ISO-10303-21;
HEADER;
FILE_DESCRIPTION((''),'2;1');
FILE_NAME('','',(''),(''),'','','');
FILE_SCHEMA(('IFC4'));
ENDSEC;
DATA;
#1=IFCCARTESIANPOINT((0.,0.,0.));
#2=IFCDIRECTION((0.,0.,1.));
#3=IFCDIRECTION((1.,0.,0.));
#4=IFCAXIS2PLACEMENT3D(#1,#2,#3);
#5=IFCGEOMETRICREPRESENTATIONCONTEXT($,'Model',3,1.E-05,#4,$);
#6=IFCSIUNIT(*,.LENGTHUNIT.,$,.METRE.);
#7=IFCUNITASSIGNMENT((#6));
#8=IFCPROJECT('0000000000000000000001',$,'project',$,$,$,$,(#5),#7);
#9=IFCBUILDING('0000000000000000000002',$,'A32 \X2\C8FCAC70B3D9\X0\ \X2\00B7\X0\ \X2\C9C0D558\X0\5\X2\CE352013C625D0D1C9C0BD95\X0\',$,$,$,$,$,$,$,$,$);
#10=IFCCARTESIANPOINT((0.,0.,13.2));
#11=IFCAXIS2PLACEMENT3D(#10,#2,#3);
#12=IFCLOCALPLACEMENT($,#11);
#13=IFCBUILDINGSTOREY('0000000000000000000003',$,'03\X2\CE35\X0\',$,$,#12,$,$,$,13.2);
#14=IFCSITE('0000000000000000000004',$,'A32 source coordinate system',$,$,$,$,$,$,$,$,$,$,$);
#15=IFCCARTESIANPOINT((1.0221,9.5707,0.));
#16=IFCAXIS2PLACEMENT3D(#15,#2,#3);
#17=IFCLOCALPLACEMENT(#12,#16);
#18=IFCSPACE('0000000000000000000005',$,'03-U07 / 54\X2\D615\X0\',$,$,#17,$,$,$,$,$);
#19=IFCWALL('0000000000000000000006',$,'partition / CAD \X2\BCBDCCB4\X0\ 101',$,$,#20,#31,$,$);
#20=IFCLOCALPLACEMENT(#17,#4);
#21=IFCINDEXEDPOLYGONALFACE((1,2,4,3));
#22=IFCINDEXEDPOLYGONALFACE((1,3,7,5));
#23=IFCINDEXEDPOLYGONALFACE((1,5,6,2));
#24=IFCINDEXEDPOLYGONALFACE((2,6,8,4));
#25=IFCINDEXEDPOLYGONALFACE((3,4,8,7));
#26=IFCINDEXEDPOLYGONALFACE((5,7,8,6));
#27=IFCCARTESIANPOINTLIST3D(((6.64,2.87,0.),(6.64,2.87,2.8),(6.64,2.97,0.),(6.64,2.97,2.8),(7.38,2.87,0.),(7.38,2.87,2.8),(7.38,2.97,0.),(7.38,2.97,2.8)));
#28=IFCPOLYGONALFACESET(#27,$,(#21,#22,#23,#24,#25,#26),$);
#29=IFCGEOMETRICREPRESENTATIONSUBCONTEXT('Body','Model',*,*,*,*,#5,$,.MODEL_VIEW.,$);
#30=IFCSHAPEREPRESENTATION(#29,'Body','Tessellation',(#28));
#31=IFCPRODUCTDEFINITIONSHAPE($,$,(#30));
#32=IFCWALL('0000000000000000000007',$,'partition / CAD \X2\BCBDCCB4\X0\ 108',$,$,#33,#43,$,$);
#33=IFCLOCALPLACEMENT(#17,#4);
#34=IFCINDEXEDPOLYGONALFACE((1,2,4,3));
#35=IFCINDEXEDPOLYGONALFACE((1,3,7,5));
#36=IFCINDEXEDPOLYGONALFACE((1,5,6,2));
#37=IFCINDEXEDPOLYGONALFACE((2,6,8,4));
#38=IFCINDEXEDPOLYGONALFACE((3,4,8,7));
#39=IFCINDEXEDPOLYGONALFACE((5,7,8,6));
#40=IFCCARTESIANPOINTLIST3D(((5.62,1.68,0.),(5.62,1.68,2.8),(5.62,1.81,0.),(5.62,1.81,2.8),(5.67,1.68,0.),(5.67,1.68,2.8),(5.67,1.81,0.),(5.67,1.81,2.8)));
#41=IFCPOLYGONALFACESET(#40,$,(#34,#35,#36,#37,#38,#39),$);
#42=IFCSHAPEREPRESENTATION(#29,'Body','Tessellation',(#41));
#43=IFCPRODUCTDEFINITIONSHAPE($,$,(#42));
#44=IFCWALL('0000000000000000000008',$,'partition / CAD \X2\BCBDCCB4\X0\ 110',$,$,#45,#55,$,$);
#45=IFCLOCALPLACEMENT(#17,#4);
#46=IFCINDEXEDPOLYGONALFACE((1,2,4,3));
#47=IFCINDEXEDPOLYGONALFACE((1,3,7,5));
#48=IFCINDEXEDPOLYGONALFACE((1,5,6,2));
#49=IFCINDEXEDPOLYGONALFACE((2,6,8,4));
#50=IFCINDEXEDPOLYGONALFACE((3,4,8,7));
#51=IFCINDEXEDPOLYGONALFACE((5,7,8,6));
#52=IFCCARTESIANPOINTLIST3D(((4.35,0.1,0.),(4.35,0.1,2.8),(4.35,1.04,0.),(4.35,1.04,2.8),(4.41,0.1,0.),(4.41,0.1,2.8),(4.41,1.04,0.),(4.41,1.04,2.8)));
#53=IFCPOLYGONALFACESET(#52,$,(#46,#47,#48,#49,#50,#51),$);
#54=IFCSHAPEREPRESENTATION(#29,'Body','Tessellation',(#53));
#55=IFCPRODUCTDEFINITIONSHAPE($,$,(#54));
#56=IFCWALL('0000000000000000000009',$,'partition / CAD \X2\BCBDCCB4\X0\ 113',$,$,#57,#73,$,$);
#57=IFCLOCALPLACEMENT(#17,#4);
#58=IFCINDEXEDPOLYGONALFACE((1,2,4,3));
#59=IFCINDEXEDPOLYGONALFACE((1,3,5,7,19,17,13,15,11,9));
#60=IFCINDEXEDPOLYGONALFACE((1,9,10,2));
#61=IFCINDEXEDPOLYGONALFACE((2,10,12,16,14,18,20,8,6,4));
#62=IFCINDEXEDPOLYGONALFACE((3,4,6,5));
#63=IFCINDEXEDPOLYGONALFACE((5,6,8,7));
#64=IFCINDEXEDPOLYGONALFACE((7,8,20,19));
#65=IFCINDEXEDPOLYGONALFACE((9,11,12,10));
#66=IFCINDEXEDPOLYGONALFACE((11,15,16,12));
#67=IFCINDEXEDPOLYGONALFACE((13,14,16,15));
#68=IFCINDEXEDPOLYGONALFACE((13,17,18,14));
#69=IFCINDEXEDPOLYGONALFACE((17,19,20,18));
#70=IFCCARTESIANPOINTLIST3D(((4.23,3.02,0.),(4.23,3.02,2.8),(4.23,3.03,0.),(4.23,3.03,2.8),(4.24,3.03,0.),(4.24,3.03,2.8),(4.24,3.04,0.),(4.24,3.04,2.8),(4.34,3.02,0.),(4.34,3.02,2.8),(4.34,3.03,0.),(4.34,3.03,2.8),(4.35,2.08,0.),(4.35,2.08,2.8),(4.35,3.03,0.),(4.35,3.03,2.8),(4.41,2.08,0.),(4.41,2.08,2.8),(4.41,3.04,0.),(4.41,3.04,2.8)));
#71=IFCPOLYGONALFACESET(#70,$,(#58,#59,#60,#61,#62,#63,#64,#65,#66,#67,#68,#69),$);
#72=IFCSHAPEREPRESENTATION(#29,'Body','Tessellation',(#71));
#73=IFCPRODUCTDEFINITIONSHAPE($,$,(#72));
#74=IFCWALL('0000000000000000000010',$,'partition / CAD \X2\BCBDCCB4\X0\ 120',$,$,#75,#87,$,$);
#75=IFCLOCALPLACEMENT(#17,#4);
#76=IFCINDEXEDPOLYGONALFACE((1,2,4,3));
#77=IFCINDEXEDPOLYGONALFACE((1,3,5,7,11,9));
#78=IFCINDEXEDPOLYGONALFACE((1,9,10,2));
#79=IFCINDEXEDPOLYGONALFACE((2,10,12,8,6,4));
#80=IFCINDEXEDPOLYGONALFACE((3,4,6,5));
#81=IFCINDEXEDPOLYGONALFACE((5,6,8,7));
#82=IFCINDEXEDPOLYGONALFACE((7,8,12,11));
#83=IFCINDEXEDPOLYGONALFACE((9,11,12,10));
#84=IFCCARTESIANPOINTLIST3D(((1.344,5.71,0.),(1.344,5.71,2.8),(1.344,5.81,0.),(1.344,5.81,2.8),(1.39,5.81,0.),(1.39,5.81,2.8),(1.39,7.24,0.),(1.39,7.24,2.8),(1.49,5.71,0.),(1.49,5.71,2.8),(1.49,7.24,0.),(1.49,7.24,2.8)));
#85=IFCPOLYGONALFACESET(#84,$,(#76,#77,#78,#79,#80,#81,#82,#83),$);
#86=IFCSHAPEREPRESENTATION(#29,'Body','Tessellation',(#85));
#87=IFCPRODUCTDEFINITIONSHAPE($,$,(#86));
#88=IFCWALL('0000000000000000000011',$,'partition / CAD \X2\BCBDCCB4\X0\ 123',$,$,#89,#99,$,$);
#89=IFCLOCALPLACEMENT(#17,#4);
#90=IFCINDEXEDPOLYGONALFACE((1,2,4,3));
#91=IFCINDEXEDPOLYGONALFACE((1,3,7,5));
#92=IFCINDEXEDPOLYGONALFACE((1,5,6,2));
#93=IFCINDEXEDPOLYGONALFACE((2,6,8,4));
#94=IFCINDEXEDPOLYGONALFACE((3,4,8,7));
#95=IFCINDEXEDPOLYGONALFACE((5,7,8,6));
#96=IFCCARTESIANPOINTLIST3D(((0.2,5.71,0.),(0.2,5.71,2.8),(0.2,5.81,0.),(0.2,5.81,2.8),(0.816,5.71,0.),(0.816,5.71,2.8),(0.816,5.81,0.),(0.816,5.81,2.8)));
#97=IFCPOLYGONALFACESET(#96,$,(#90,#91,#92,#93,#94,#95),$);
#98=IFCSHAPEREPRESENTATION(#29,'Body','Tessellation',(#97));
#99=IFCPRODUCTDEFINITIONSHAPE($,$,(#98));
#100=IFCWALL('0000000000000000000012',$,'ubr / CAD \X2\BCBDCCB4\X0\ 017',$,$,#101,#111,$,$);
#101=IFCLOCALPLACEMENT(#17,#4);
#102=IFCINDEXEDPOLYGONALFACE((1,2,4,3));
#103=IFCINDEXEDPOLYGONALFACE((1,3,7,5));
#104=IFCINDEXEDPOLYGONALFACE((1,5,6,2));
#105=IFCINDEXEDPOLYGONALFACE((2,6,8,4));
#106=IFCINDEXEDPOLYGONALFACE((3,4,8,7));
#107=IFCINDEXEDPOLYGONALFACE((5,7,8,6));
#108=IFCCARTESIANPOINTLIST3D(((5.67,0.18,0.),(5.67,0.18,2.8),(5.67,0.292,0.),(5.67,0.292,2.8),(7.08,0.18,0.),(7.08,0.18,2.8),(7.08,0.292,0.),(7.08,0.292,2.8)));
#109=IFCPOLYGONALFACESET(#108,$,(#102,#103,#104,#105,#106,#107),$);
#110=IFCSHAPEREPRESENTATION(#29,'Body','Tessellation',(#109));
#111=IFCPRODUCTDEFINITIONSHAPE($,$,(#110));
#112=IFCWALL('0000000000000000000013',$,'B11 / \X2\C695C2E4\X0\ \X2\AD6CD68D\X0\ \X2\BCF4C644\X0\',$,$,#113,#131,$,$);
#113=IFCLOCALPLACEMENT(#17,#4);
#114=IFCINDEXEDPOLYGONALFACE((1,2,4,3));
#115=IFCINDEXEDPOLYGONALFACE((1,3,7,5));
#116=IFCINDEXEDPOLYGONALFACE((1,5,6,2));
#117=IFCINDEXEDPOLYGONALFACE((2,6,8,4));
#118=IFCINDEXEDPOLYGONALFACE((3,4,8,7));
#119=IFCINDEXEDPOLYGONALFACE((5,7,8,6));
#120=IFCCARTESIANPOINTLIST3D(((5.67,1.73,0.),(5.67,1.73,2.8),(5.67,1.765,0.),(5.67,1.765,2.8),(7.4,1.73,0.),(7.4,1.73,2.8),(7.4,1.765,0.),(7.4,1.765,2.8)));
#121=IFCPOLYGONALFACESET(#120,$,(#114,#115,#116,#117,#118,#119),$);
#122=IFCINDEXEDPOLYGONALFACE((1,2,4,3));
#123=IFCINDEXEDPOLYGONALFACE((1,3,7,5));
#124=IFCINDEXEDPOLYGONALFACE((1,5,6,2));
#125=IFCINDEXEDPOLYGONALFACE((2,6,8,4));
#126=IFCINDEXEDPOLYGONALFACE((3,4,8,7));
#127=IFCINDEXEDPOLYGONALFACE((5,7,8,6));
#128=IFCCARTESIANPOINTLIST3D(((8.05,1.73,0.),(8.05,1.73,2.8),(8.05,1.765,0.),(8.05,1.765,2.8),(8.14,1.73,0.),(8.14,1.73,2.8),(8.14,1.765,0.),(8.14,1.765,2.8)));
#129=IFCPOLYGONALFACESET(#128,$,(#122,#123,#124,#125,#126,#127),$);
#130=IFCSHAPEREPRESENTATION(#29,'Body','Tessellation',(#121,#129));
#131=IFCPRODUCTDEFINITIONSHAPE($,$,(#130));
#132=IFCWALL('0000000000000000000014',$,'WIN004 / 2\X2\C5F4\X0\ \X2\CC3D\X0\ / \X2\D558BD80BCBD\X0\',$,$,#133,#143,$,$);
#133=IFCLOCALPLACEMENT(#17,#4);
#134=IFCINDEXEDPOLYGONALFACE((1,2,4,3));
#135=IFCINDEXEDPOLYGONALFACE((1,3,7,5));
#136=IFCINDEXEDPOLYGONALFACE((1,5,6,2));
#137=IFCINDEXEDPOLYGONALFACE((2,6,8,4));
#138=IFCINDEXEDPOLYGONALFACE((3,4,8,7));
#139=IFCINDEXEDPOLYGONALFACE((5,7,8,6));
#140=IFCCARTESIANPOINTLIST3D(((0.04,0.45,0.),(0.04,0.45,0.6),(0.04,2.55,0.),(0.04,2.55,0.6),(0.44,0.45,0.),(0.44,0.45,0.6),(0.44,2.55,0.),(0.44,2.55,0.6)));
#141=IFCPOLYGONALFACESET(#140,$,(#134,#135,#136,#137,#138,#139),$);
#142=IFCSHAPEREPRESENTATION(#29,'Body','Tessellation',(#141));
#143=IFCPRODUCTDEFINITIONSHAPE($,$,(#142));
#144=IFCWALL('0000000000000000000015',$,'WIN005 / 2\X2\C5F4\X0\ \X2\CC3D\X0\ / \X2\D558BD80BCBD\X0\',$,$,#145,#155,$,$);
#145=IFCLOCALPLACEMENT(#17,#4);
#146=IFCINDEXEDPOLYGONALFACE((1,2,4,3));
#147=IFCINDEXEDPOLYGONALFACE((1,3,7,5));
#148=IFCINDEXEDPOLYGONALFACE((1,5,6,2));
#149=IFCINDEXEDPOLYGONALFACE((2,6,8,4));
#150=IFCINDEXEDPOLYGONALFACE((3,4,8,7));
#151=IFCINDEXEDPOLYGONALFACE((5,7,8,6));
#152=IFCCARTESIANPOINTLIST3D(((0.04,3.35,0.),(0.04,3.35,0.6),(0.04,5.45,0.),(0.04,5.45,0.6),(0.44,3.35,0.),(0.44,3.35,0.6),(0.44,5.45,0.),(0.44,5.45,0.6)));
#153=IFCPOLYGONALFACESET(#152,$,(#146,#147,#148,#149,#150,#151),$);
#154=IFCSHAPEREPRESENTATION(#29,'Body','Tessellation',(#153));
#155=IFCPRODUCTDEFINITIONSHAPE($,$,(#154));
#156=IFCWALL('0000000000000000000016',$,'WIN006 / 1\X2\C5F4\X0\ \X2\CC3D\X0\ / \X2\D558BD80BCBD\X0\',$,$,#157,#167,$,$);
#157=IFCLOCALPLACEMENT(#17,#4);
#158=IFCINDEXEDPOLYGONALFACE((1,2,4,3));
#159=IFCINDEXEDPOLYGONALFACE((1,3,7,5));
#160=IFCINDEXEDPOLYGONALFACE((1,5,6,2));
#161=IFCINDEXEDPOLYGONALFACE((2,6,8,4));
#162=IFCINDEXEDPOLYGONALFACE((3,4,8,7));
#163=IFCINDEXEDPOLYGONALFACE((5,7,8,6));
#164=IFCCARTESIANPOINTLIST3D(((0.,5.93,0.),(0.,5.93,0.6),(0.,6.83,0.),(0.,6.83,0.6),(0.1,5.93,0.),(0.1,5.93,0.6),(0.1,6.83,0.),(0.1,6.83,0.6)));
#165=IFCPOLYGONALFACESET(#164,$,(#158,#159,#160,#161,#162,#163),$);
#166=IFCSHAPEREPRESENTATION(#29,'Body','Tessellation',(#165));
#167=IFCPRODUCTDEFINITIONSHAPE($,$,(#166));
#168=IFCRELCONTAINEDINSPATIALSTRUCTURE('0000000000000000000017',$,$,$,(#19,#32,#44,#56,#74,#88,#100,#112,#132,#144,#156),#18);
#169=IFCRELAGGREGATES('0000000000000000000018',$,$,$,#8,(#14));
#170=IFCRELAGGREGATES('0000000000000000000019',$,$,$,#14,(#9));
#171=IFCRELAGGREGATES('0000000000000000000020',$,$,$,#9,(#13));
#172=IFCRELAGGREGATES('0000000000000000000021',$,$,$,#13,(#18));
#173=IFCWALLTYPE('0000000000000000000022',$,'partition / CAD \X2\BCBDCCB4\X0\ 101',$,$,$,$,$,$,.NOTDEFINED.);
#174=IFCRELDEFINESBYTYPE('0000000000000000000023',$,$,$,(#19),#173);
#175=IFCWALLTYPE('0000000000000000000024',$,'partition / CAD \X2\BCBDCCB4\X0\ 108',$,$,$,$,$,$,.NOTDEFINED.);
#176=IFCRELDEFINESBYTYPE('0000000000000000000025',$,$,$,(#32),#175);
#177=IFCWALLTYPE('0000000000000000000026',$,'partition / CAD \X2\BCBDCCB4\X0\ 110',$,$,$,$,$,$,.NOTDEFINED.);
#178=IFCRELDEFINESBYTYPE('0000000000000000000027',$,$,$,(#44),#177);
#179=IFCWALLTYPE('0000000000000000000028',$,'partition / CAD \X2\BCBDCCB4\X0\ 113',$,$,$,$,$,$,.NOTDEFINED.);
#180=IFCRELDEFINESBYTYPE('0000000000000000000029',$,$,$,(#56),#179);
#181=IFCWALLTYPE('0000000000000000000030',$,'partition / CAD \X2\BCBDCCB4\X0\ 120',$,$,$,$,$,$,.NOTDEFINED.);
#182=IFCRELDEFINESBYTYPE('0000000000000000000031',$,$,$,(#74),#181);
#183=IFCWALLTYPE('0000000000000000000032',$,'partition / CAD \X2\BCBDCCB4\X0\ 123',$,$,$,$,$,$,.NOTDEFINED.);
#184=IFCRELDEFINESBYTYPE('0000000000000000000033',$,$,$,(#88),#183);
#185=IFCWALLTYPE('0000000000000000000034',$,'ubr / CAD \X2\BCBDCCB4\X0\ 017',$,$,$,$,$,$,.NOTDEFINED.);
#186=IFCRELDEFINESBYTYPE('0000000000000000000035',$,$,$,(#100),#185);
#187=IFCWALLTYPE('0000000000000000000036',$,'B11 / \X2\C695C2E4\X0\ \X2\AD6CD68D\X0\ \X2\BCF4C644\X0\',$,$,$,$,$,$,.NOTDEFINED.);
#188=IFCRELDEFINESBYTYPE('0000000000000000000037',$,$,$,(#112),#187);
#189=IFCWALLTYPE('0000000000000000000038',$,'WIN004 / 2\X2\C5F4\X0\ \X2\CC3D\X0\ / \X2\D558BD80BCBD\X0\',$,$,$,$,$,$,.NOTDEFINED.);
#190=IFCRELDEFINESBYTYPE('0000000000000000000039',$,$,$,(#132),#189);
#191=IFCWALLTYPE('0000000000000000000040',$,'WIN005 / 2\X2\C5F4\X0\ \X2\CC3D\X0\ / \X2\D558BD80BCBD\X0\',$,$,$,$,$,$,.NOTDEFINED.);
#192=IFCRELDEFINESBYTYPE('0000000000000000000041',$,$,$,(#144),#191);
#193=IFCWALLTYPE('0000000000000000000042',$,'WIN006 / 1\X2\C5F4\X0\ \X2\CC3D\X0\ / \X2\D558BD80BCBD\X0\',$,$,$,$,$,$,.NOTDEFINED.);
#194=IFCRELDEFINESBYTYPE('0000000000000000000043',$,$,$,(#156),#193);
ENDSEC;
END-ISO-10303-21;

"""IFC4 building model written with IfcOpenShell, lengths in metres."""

from ifc_helpers import new_model, si_unit, frame, origin, origin_with_axes, place, context, subcontext, project, spatial, polyline, outline, extrude, source, transform, mapped, type_object, type_shapes, element, save


model = new_model("IFC4")

# Units and contexts
model_context = context("Model", 3, precision=1e-05, world=origin_with_axes())
body_context = subcontext(model_context, "Body", "Model", "MODEL_VIEW")
ifc_project = project(units=[si_unit("LENGTHUNIT", "METRE")], contexts=[model_context])

# Site, building, storey
storey_placement = place(None, frame((0.0, 0.0, 13.2), z_axis=(0.0, 0.0, 1.0), x_axis=(1.0, 0.0, 0.0)))
site = spatial("IfcSite", under=ifc_project, Name="A32 source coordinate system")
building = spatial("IfcBuilding", under=site, Name="A32 주거동 · 지하5층–옥탑지붕")
storey = spatial("IfcBuildingStorey", under=building, at=storey_placement, Name="03층", Elevation=13.2)

# Shared definitions
space_1_placement = place(storey_placement, frame((1.0221, 9.5707, 0.0), z_axis=(0.0, 0.0, 1.0), x_axis=(1.0, 0.0, 0.0)))
space_1 = spatial("IfcSpace", under=storey, at=space_1_placement, Name="03-U07 / 54형")

# Walls
wall_type_1 = type_object("IfcWallType", Name="partition / CAD 벽체 101", PredefinedType="NOTDEFINED")
shared_shape_1 = source(origin(), body_context, "Body", "SweptSolid", [
    extrude(outline(polyline([(7.38, 2.97), (7.38, 2.87), (6.64, 2.87), (6.64, 2.97), (7.38, 2.97)])), origin(), (0.0, 0.0, 1.0), 2.8),
])
type_shapes(wall_type_1, [shared_shape_1])
wall_1_placement = place(space_1_placement, origin_with_axes())
element("IfcWall", 1, at=wall_1_placement, inside=space_1, type_object=wall_type_1, Name="partition / CAD 벽체 101", context=body_context, shape_type="MappedRepresentation", body=[
    mapped(shared_shape_1, transform((0.0, 0.0, 0.0), scale=1.0)),
])
wall_type_2 = type_object("IfcWallType", Name="partition / CAD 벽체 108", PredefinedType="NOTDEFINED")
shared_shape_2 = source(origin(), body_context, "Body", "SweptSolid", [
    extrude(outline(polyline([(5.67, 1.68), (5.62, 1.68), (5.62, 1.81), (5.67, 1.81), (5.67, 1.68)])), origin(), (0.0, 0.0, 1.0), 2.8),
])
type_shapes(wall_type_2, [shared_shape_2])
wall_2_placement = place(space_1_placement, origin_with_axes())
element("IfcWall", 2, at=wall_2_placement, inside=space_1, type_object=wall_type_2, Name="partition / CAD 벽체 108", context=body_context, shape_type="MappedRepresentation", body=[
    mapped(shared_shape_2, transform((0.0, 0.0, 0.0), scale=1.0)),
])
wall_type_3 = type_object("IfcWallType", Name="partition / CAD 벽체 110", PredefinedType="NOTDEFINED")
shared_shape_3 = source(origin(), body_context, "Body", "SweptSolid", [
    extrude(outline(polyline([(4.35, 1.04), (4.41, 1.04), (4.41, 0.1), (4.35, 0.1), (4.35, 1.04)])), origin(), (0.0, 0.0, 1.0), 2.8),
])
type_shapes(wall_type_3, [shared_shape_3])
wall_3_placement = place(space_1_placement, origin_with_axes())
element("IfcWall", 3, at=wall_3_placement, inside=space_1, type_object=wall_type_3, Name="partition / CAD 벽체 110", context=body_context, shape_type="MappedRepresentation", body=[
    mapped(shared_shape_3, transform((0.0, 0.0, 0.0), scale=1.0)),
])
wall_type_4 = type_object("IfcWallType", Name="partition / CAD 벽체 113", PredefinedType="NOTDEFINED")
shared_shape_4 = source(origin(), body_context, "Body", "SweptSolid", [
    extrude(outline(polyline([(4.24, 3.04), (4.41, 3.04), (4.41, 2.08), (4.35, 2.08), (4.35, 3.03), (4.34, 3.03), (4.34, 3.02), (4.23, 3.02), (4.23, 3.03), (4.24, 3.03), (4.24, 3.04)])), origin(), (0.0, 0.0, 1.0), 2.8),
])
type_shapes(wall_type_4, [shared_shape_4])
wall_4_placement = place(space_1_placement, origin_with_axes())
element("IfcWall", 4, at=wall_4_placement, inside=space_1, type_object=wall_type_4, Name="partition / CAD 벽체 113", context=body_context, shape_type="MappedRepresentation", body=[
    mapped(shared_shape_4, transform((0.0, 0.0, 0.0), scale=1.0)),
])
wall_type_5 = type_object("IfcWallType", Name="partition / CAD 벽체 120", PredefinedType="NOTDEFINED")
shared_shape_5 = source(origin(), body_context, "Body", "SweptSolid", [
    extrude(outline(polyline([(1.39, 7.24), (1.49, 7.24), (1.49, 5.71), (1.344, 5.71), (1.344, 5.81), (1.39, 5.81), (1.39, 7.24)])), origin(), (0.0, 0.0, 1.0), 2.8),
])
type_shapes(wall_type_5, [shared_shape_5])
wall_5_placement = place(space_1_placement, origin_with_axes())
element("IfcWall", 5, at=wall_5_placement, inside=space_1, type_object=wall_type_5, Name="partition / CAD 벽체 120", context=body_context, shape_type="MappedRepresentation", body=[
    mapped(shared_shape_5, transform((0.0, 0.0, 0.0), scale=1.0)),
])
wall_type_6 = type_object("IfcWallType", Name="partition / CAD 벽체 123", PredefinedType="NOTDEFINED")
shared_shape_6 = source(origin(), body_context, "Body", "SweptSolid", [
    extrude(outline(polyline([(0.816, 5.81), (0.816, 5.71), (0.2, 5.71), (0.2, 5.81), (0.816, 5.81)])), origin(), (0.0, 0.0, 1.0), 2.8),
])
type_shapes(wall_type_6, [shared_shape_6])
wall_6_placement = place(space_1_placement, origin_with_axes())
element("IfcWall", 6, at=wall_6_placement, inside=space_1, type_object=wall_type_6, Name="partition / CAD 벽체 123", context=body_context, shape_type="MappedRepresentation", body=[
    mapped(shared_shape_6, transform((0.0, 0.0, 0.0), scale=1.0)),
])
wall_type_7 = type_object("IfcWallType", Name="ubr / CAD 벽체 017", PredefinedType="NOTDEFINED")
shared_shape_7 = source(origin(), body_context, "Body", "SweptSolid", [
    extrude(outline(polyline([(7.08, 0.292), (7.08, 0.18), (5.67, 0.18), (5.67, 0.292), (7.08, 0.292)])), origin(), (0.0, 0.0, 1.0), 2.8),
])
type_shapes(wall_type_7, [shared_shape_7])
wall_7_placement = place(space_1_placement, origin_with_axes())
element("IfcWall", 7, at=wall_7_placement, inside=space_1, type_object=wall_type_7, Name="ubr / CAD 벽체 017", context=body_context, shape_type="MappedRepresentation", body=[
    mapped(shared_shape_7, transform((0.0, 0.0, 0.0), scale=1.0)),
])
wall_type_8 = type_object("IfcWallType", Name="B11 / 욕실 구획 보완", PredefinedType="NOTDEFINED")
shared_shape_8 = source(origin(), body_context, "Body", "SweptSolid", [
    extrude(outline(polyline([(7.4, 1.765), (7.4, 1.73), (5.67, 1.73), (5.67, 1.765), (7.4, 1.765)])), origin(), (0.0, 0.0, 1.0), 2.8),
    extrude(outline(polyline([(8.05, 1.73), (8.05, 1.765), (8.14, 1.765), (8.14, 1.73), (8.05, 1.73)])), origin(), (0.0, 0.0, 1.0), 2.8),
])
type_shapes(wall_type_8, [shared_shape_8])
wall_8_placement = place(space_1_placement, origin_with_axes())
element("IfcWall", 8, at=wall_8_placement, inside=space_1, type_object=wall_type_8, Name="B11 / 욕실 구획 보완", context=body_context, shape_type="MappedRepresentation", body=[
    mapped(shared_shape_8, transform((0.0, 0.0, 0.0), scale=1.0)),
])
wall_type_9 = type_object("IfcWallType", Name="WIN004 / 2열 창 / 하부벽", PredefinedType="NOTDEFINED")
shared_shape_9 = source(origin(), body_context, "Body", "SweptSolid", [
    extrude(outline(polyline([(0.44, 0.45), (0.04, 0.45), (0.04, 2.55), (0.44, 2.55), (0.44, 0.45)])), origin(), (0.0, 0.0, 1.0), 0.6),
])
type_shapes(wall_type_9, [shared_shape_9])
wall_9_placement = place(space_1_placement, origin_with_axes())
element("IfcWall", 9, at=wall_9_placement, inside=space_1, type_object=wall_type_9, Name="WIN004 / 2열 창 / 하부벽", context=body_context, shape_type="MappedRepresentation", body=[
    mapped(shared_shape_9, transform((0.0, 0.0, 0.0), scale=1.0)),
])
wall_type_10 = type_object("IfcWallType", Name="WIN005 / 2열 창 / 하부벽", PredefinedType="NOTDEFINED")
shared_shape_10 = source(origin(), body_context, "Body", "SweptSolid", [
    extrude(outline(polyline([(0.44, 3.35), (0.04, 3.35), (0.04, 5.45), (0.44, 5.45), (0.44, 3.35)])), origin(), (0.0, 0.0, 1.0), 0.6),
])
type_shapes(wall_type_10, [shared_shape_10])
wall_10_placement = place(space_1_placement, origin_with_axes())
element("IfcWall", 10, at=wall_10_placement, inside=space_1, type_object=wall_type_10, Name="WIN005 / 2열 창 / 하부벽", context=body_context, shape_type="MappedRepresentation", body=[
    mapped(shared_shape_10, transform((0.0, 0.0, 0.0), scale=1.0)),
])
wall_type_11 = type_object("IfcWallType", Name="WIN006 / 1열 창 / 하부벽", PredefinedType="NOTDEFINED")
shared_shape_11 = source(origin(), body_context, "Body", "SweptSolid", [
    extrude(outline(polyline([(0.1, 5.93), (0.0, 5.93), (0.0, 6.83), (0.1, 6.83), (0.1, 5.93)])), origin(), (0.0, 0.0, 1.0), 0.6),
])
type_shapes(wall_type_11, [shared_shape_11])
wall_11_placement = place(space_1_placement, origin_with_axes())
element("IfcWall", 11, at=wall_11_placement, inside=space_1, type_object=wall_type_11, Name="WIN006 / 1열 창 / 하부벽", context=body_context, shape_type="MappedRepresentation", body=[
    mapped(shared_shape_11, transform((0.0, 0.0, 0.0), scale=1.0)),
])

save(model, "model.ifc")
